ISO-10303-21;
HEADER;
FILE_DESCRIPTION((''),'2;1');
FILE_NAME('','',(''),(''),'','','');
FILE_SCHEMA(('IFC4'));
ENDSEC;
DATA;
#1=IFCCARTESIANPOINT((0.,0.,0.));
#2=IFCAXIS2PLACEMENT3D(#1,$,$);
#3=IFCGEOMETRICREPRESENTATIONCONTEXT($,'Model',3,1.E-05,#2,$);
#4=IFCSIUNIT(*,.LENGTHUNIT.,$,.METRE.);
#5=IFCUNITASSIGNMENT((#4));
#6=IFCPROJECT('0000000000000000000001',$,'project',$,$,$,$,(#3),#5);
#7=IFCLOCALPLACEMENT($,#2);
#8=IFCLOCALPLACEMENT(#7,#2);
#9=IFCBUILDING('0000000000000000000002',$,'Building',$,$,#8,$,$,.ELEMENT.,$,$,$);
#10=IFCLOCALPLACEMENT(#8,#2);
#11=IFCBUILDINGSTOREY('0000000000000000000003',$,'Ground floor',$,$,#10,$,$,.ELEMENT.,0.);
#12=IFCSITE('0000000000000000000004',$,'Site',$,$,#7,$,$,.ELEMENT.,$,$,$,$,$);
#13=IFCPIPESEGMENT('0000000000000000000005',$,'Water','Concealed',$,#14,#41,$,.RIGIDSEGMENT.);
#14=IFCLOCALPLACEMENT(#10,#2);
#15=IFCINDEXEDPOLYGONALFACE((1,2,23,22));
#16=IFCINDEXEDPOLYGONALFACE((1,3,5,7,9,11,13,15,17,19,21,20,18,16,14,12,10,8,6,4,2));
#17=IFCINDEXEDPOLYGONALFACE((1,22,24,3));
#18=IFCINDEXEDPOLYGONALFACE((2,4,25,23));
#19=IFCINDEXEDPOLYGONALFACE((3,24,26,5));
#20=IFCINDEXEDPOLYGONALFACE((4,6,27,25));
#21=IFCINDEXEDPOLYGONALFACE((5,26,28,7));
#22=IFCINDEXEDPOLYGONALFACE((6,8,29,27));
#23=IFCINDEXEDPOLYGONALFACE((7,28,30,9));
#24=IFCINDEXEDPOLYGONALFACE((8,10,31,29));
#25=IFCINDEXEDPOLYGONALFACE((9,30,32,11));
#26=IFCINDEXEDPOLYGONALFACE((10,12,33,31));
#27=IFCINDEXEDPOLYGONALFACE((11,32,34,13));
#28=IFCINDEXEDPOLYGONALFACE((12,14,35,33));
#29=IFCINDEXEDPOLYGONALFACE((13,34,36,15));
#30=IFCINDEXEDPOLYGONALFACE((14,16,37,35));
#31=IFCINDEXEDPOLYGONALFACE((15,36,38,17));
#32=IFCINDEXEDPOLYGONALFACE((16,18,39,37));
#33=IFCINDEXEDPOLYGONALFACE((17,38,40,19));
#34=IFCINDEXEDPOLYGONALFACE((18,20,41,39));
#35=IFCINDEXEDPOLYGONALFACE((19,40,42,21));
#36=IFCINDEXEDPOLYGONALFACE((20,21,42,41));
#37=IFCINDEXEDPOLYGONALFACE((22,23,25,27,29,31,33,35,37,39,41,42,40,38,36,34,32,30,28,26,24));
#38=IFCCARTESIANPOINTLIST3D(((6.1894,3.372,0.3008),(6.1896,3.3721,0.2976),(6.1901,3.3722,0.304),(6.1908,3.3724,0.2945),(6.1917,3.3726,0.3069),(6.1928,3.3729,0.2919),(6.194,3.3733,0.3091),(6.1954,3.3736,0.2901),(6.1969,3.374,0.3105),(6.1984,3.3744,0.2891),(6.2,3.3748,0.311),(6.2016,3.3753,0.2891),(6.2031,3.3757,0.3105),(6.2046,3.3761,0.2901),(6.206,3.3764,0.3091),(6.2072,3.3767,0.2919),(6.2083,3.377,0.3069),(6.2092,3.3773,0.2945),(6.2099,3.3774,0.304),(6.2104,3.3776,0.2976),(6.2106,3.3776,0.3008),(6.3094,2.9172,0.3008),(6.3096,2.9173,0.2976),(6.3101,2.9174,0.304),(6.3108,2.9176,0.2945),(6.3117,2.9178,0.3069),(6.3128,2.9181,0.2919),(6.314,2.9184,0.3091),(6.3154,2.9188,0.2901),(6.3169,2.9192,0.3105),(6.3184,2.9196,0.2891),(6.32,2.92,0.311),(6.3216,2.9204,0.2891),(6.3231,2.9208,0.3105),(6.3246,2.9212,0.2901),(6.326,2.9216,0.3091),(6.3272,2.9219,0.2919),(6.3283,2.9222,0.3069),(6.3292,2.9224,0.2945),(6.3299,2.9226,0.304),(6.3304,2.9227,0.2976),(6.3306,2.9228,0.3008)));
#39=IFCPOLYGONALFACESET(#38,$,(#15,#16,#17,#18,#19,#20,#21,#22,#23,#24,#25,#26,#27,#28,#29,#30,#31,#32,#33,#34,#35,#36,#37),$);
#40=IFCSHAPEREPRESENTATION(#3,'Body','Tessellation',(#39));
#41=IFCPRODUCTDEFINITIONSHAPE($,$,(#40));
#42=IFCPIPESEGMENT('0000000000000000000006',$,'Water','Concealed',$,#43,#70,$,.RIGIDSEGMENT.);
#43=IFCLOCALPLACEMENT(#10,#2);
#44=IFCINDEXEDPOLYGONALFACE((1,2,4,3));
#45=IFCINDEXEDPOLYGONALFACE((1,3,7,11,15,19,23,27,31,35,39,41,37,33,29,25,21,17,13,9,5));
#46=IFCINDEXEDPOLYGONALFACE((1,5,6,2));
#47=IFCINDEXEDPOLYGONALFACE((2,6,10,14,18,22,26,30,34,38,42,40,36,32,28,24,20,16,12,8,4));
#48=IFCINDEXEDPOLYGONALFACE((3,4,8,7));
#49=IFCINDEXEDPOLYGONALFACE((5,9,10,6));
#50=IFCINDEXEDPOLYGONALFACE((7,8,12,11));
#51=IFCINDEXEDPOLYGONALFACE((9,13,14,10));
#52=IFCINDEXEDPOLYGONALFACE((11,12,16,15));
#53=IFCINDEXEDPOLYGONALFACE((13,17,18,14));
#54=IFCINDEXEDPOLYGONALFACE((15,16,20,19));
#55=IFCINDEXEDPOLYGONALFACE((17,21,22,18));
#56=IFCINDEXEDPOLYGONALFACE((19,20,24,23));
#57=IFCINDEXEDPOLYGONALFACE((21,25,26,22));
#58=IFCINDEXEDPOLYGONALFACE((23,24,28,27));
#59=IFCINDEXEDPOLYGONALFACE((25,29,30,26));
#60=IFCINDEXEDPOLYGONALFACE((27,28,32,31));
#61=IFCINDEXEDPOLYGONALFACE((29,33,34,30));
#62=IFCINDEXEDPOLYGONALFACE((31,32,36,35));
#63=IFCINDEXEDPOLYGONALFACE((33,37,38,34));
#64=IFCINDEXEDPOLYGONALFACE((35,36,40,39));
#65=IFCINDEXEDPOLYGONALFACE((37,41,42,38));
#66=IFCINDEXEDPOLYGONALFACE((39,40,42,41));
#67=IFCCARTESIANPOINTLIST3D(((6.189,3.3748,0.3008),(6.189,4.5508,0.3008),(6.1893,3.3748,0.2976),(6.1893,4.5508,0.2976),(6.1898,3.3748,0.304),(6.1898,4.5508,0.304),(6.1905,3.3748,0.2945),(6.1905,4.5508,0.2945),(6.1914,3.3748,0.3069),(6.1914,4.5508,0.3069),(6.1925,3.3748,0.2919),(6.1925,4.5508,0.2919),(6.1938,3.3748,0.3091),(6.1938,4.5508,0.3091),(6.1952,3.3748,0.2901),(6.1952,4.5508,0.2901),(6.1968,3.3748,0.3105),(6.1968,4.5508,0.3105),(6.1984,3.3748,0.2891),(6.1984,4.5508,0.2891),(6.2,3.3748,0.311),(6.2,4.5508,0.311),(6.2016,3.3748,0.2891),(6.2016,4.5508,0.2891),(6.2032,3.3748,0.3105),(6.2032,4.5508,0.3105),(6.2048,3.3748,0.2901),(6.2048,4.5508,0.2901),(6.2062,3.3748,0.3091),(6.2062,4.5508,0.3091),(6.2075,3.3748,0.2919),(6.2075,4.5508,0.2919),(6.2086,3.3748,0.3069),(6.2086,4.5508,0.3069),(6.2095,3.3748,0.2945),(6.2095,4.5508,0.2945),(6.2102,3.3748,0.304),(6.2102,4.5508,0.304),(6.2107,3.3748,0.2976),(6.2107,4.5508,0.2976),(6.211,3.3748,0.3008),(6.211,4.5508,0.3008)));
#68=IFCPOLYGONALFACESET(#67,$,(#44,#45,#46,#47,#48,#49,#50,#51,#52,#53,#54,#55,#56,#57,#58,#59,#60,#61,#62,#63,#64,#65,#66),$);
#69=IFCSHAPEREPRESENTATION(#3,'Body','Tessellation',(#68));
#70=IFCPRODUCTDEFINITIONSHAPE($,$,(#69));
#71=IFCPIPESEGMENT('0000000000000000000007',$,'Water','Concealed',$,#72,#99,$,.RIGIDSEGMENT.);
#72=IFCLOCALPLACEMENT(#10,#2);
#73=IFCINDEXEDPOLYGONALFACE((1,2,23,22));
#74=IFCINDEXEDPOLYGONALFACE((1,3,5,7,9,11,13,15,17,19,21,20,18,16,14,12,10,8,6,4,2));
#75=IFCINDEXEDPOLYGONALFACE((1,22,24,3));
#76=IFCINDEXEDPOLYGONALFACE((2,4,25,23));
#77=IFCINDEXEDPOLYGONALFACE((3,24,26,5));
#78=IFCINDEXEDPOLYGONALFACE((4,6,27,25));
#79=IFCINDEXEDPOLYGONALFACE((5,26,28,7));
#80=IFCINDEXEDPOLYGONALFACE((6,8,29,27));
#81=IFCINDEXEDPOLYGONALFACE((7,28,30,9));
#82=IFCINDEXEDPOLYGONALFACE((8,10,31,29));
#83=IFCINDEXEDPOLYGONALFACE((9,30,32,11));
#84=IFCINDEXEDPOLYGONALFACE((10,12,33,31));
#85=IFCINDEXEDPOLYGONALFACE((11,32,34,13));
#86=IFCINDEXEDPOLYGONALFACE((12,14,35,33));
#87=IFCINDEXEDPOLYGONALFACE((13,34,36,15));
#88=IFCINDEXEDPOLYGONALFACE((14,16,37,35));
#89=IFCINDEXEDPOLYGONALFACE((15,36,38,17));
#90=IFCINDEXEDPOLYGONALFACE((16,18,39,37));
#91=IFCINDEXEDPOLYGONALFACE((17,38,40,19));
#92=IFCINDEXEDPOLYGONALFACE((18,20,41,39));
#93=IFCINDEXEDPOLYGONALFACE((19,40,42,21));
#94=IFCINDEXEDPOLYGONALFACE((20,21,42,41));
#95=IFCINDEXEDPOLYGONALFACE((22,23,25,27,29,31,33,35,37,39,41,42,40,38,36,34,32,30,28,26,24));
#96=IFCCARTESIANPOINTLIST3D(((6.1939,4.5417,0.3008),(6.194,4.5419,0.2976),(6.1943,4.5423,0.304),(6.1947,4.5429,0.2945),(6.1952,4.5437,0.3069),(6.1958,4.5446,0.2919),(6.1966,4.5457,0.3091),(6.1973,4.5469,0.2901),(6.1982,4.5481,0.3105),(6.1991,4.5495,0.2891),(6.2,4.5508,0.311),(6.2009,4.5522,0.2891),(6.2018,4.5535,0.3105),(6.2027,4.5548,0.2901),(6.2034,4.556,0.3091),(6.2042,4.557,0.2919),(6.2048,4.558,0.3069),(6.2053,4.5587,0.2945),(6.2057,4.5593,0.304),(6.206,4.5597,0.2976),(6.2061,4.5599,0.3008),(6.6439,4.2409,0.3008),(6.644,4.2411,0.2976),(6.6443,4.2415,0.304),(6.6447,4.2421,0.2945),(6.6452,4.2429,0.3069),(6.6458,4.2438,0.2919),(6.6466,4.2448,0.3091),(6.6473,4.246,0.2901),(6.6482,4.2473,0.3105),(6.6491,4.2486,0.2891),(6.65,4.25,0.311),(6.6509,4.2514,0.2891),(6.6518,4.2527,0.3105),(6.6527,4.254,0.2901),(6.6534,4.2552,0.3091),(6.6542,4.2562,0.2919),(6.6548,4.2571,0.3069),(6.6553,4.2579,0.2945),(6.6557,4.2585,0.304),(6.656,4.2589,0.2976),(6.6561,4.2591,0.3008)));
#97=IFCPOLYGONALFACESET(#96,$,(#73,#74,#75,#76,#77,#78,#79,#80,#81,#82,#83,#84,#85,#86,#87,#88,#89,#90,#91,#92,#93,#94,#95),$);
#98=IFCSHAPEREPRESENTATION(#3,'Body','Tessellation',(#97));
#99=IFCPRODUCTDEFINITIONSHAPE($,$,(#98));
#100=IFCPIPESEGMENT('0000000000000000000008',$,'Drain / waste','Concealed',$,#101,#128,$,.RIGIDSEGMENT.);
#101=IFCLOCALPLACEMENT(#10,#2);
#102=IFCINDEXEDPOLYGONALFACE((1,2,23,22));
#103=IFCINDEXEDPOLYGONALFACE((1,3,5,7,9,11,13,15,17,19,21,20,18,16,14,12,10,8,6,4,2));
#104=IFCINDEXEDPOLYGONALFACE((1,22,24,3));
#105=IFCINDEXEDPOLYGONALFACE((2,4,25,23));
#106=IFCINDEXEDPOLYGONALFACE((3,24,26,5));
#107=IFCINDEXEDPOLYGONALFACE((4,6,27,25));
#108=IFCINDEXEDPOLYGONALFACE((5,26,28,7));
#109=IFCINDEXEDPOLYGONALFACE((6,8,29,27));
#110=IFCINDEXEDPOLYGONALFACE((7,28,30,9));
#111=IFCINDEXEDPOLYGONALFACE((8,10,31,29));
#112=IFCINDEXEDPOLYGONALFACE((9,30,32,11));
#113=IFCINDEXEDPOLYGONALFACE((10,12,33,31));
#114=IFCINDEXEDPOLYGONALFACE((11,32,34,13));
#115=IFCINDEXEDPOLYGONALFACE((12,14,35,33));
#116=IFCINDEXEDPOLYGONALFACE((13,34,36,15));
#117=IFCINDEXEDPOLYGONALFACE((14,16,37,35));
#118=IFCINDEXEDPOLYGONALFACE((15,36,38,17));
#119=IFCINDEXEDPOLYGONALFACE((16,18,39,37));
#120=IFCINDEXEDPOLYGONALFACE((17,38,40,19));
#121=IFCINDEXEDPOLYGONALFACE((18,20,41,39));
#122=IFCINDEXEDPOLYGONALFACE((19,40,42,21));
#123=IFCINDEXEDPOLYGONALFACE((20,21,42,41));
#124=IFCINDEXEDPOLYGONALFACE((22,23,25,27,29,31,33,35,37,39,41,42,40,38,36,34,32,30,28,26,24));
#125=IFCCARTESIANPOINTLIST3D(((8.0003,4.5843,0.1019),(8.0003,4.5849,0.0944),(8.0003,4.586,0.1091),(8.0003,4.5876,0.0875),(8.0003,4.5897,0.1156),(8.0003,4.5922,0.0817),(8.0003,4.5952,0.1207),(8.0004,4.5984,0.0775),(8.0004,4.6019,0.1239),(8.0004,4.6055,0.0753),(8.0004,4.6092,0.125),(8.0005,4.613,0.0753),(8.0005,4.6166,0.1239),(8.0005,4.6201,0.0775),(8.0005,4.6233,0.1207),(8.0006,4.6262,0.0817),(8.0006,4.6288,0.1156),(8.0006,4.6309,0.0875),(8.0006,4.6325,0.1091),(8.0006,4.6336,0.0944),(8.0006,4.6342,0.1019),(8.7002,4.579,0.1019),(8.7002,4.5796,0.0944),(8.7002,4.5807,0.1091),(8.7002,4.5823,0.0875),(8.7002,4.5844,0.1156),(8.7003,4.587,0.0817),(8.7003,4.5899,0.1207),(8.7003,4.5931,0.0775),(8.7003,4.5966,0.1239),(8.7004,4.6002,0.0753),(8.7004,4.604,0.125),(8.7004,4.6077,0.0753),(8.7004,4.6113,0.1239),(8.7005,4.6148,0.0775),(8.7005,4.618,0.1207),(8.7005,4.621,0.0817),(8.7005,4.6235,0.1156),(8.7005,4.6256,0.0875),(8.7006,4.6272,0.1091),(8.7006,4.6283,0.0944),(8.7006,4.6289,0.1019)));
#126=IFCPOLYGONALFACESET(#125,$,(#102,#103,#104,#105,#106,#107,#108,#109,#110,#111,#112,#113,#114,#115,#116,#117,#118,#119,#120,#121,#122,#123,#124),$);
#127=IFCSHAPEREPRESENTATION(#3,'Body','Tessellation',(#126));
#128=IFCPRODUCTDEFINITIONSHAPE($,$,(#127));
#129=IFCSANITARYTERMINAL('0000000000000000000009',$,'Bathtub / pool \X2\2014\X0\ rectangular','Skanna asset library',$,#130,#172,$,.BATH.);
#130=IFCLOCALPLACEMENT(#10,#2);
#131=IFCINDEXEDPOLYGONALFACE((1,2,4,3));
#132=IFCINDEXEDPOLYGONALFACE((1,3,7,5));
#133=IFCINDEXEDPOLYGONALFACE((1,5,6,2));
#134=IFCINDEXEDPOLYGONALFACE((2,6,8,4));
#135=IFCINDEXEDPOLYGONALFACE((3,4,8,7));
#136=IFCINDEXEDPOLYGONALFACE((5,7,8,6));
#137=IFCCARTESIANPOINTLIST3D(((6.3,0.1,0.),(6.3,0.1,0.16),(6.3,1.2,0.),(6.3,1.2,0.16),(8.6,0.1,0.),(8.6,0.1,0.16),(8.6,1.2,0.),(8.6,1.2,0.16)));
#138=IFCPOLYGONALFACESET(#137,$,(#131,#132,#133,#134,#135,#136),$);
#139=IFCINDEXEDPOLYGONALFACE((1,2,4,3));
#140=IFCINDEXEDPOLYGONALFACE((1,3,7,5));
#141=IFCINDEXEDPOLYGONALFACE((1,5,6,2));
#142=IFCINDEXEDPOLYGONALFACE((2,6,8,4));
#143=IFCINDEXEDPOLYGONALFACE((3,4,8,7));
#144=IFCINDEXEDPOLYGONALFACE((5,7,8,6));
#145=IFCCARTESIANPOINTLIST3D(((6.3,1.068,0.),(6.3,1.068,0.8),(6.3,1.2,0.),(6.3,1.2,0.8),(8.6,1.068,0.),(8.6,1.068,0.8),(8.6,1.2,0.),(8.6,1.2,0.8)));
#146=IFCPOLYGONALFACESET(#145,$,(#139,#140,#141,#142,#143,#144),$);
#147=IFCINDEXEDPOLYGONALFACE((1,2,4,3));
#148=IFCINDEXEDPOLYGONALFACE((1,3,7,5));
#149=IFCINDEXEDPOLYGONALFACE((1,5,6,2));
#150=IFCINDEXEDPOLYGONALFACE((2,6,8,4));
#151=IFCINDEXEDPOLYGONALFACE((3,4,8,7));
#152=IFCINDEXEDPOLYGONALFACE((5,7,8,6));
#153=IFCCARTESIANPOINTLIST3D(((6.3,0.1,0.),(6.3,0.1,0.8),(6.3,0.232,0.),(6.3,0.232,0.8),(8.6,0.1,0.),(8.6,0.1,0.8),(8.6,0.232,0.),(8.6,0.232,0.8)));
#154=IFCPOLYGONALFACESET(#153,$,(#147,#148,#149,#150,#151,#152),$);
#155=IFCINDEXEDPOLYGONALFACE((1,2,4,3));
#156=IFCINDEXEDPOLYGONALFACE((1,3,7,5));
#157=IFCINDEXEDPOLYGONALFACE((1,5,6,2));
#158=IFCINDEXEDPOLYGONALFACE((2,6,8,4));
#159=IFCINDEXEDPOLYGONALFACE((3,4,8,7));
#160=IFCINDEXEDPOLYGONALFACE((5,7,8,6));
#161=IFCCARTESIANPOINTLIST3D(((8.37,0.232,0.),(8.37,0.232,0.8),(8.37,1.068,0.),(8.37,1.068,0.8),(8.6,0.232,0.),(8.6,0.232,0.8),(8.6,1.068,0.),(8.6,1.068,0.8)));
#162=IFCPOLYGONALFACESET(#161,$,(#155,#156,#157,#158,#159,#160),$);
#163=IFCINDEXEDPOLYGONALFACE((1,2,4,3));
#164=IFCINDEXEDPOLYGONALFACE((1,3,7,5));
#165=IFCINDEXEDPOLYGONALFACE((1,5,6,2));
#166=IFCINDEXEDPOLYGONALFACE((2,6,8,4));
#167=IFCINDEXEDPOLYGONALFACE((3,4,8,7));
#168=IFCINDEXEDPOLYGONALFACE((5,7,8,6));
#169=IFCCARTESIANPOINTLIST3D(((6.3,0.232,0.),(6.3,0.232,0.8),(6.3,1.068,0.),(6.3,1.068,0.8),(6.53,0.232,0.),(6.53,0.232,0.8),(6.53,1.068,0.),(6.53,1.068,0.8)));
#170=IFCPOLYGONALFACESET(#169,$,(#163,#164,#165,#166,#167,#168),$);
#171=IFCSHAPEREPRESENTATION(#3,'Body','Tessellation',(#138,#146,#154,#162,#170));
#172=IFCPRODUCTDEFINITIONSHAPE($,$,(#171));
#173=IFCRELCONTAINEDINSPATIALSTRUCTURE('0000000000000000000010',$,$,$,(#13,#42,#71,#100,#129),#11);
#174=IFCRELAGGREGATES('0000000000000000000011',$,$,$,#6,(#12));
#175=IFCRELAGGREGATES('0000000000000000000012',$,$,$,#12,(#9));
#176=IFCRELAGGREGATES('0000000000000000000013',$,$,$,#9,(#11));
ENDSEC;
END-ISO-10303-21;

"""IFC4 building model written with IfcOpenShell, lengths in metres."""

from ifc_helpers import new_model, si_unit, frame, frame_2d, origin, origin_2d, place, context, project, spatial, rectangle, circle, extrude, element, save


model = new_model("IFC4")

# Units and contexts
model_context = context("Model", 3, precision=1e-05, world=origin())
ifc_project = project(units=[si_unit("LENGTHUNIT", "METRE")], contexts=[model_context])

# Site, building, storey
site_placement = place(None, origin())
site = spatial("IfcSite", under=ifc_project, at=site_placement, Name="Site", CompositionType="ELEMENT")
building_placement = place(site_placement, origin())
building = spatial("IfcBuilding", under=site, at=building_placement, Name="Building", CompositionType="ELEMENT")
storey_placement = place(building_placement, origin())
storey = spatial("IfcBuildingStorey", under=building, at=storey_placement, Name="Ground floor", CompositionType="ELEMENT", Elevation=0.0)

# Pipe segments
pipe_segment_1_placement = place(storey_placement, frame((6.32, 2.92, 0.3), z_axis=(-0.255102, 0.966914, 0.0), x_axis=(0.0, 0.0, 1.0)))
element("IfcPipeSegment", 1, at=pipe_segment_1_placement, inside=storey, Name="Water", Description="Concealed", PredefinedType="RIGIDSEGMENT", context=model_context, shape_type="SweptSolid", body=[
    extrude(circle(Radius=0.011, at=origin_2d()), origin(), (0.0, 0.0, 1.0), 0.4704),
])
pipe_segment_2_placement = place(storey_placement, frame((6.2, 3.3748, 0.3), z_axis=(0.0, 1.0, 0.0), x_axis=(0.0, 0.0, 1.0)))
element("IfcPipeSegment", 2, at=pipe_segment_2_placement, inside=storey, Name="Water", Description="Concealed", PredefinedType="RIGIDSEGMENT", context=model_context, shape_type="SweptSolid", body=[
    extrude(circle(Radius=0.011, at=origin_2d()), origin(), (0.0, 0.0, 1.0), 1.176),
])
pipe_segment_3_placement = place(storey_placement, frame((6.2, 4.5508, 0.3), z_axis=(0.831345, -0.555757, 0.0), x_axis=(0.0, 0.0, 1.0)))
element("IfcPipeSegment", 3, at=pipe_segment_3_placement, inside=storey, Name="Water", Description="Concealed", PredefinedType="RIGIDSEGMENT", context=model_context, shape_type="SweptSolid", body=[
    extrude(circle(Radius=0.011, at=origin_2d()), origin(), (0.0, 0.0, 1.0), 0.5413),
])
pipe_segment_4_placement = place(storey_placement, frame((8.0004, 4.6092, 0.1), z_axis=(0.999972, -0.007547, 0.0), x_axis=(0.0, 0.0, 1.0)))
element("IfcPipeSegment", 4, at=pipe_segment_4_placement, inside=storey, Name="Drain / waste", Description="Concealed", PredefinedType="RIGIDSEGMENT", context=model_context, shape_type="SweptSolid", body=[
    extrude(circle(Radius=0.025, at=origin_2d()), origin(), (0.0, 0.0, 1.0), 0.7),
])

# Sanitary terminal
sanitary_terminal_1_placement = place(storey_placement, frame((7.45, 0.65, 0.0), z_axis=(0.0, 0.0, 1.0), x_axis=(-1.0, 0.0, 0.0)))
element("IfcSanitaryTerminal", 5, at=sanitary_terminal_1_placement, inside=storey, Name="Bathtub / pool — rectangular", Description="Skanna asset library", PredefinedType="BATH", context=model_context, shape_type="SweptSolid", body=[
    extrude(rectangle(XDim=2.3, YDim=1.1, at=origin_2d()), origin(), (0.0, 0.0, 1.0), 0.16),
    extrude(rectangle(XDim=2.3, YDim=0.132, at=frame_2d((0.0, -0.484))), origin(), (0.0, 0.0, 1.0), 0.8),
    extrude(rectangle(XDim=2.3, YDim=0.132, at=frame_2d((0.0, 0.484))), origin(), (0.0, 0.0, 1.0), 0.8),
    extrude(rectangle(XDim=0.23, YDim=0.836, at=frame_2d((-1.035, 0.0))), origin(), (0.0, 0.0, 1.0), 0.8),
    extrude(rectangle(XDim=0.23, YDim=0.836, at=frame_2d((1.035, 0.0))), origin(), (0.0, 0.0, 1.0), 0.8),
])

save(model, "model.ifc")
